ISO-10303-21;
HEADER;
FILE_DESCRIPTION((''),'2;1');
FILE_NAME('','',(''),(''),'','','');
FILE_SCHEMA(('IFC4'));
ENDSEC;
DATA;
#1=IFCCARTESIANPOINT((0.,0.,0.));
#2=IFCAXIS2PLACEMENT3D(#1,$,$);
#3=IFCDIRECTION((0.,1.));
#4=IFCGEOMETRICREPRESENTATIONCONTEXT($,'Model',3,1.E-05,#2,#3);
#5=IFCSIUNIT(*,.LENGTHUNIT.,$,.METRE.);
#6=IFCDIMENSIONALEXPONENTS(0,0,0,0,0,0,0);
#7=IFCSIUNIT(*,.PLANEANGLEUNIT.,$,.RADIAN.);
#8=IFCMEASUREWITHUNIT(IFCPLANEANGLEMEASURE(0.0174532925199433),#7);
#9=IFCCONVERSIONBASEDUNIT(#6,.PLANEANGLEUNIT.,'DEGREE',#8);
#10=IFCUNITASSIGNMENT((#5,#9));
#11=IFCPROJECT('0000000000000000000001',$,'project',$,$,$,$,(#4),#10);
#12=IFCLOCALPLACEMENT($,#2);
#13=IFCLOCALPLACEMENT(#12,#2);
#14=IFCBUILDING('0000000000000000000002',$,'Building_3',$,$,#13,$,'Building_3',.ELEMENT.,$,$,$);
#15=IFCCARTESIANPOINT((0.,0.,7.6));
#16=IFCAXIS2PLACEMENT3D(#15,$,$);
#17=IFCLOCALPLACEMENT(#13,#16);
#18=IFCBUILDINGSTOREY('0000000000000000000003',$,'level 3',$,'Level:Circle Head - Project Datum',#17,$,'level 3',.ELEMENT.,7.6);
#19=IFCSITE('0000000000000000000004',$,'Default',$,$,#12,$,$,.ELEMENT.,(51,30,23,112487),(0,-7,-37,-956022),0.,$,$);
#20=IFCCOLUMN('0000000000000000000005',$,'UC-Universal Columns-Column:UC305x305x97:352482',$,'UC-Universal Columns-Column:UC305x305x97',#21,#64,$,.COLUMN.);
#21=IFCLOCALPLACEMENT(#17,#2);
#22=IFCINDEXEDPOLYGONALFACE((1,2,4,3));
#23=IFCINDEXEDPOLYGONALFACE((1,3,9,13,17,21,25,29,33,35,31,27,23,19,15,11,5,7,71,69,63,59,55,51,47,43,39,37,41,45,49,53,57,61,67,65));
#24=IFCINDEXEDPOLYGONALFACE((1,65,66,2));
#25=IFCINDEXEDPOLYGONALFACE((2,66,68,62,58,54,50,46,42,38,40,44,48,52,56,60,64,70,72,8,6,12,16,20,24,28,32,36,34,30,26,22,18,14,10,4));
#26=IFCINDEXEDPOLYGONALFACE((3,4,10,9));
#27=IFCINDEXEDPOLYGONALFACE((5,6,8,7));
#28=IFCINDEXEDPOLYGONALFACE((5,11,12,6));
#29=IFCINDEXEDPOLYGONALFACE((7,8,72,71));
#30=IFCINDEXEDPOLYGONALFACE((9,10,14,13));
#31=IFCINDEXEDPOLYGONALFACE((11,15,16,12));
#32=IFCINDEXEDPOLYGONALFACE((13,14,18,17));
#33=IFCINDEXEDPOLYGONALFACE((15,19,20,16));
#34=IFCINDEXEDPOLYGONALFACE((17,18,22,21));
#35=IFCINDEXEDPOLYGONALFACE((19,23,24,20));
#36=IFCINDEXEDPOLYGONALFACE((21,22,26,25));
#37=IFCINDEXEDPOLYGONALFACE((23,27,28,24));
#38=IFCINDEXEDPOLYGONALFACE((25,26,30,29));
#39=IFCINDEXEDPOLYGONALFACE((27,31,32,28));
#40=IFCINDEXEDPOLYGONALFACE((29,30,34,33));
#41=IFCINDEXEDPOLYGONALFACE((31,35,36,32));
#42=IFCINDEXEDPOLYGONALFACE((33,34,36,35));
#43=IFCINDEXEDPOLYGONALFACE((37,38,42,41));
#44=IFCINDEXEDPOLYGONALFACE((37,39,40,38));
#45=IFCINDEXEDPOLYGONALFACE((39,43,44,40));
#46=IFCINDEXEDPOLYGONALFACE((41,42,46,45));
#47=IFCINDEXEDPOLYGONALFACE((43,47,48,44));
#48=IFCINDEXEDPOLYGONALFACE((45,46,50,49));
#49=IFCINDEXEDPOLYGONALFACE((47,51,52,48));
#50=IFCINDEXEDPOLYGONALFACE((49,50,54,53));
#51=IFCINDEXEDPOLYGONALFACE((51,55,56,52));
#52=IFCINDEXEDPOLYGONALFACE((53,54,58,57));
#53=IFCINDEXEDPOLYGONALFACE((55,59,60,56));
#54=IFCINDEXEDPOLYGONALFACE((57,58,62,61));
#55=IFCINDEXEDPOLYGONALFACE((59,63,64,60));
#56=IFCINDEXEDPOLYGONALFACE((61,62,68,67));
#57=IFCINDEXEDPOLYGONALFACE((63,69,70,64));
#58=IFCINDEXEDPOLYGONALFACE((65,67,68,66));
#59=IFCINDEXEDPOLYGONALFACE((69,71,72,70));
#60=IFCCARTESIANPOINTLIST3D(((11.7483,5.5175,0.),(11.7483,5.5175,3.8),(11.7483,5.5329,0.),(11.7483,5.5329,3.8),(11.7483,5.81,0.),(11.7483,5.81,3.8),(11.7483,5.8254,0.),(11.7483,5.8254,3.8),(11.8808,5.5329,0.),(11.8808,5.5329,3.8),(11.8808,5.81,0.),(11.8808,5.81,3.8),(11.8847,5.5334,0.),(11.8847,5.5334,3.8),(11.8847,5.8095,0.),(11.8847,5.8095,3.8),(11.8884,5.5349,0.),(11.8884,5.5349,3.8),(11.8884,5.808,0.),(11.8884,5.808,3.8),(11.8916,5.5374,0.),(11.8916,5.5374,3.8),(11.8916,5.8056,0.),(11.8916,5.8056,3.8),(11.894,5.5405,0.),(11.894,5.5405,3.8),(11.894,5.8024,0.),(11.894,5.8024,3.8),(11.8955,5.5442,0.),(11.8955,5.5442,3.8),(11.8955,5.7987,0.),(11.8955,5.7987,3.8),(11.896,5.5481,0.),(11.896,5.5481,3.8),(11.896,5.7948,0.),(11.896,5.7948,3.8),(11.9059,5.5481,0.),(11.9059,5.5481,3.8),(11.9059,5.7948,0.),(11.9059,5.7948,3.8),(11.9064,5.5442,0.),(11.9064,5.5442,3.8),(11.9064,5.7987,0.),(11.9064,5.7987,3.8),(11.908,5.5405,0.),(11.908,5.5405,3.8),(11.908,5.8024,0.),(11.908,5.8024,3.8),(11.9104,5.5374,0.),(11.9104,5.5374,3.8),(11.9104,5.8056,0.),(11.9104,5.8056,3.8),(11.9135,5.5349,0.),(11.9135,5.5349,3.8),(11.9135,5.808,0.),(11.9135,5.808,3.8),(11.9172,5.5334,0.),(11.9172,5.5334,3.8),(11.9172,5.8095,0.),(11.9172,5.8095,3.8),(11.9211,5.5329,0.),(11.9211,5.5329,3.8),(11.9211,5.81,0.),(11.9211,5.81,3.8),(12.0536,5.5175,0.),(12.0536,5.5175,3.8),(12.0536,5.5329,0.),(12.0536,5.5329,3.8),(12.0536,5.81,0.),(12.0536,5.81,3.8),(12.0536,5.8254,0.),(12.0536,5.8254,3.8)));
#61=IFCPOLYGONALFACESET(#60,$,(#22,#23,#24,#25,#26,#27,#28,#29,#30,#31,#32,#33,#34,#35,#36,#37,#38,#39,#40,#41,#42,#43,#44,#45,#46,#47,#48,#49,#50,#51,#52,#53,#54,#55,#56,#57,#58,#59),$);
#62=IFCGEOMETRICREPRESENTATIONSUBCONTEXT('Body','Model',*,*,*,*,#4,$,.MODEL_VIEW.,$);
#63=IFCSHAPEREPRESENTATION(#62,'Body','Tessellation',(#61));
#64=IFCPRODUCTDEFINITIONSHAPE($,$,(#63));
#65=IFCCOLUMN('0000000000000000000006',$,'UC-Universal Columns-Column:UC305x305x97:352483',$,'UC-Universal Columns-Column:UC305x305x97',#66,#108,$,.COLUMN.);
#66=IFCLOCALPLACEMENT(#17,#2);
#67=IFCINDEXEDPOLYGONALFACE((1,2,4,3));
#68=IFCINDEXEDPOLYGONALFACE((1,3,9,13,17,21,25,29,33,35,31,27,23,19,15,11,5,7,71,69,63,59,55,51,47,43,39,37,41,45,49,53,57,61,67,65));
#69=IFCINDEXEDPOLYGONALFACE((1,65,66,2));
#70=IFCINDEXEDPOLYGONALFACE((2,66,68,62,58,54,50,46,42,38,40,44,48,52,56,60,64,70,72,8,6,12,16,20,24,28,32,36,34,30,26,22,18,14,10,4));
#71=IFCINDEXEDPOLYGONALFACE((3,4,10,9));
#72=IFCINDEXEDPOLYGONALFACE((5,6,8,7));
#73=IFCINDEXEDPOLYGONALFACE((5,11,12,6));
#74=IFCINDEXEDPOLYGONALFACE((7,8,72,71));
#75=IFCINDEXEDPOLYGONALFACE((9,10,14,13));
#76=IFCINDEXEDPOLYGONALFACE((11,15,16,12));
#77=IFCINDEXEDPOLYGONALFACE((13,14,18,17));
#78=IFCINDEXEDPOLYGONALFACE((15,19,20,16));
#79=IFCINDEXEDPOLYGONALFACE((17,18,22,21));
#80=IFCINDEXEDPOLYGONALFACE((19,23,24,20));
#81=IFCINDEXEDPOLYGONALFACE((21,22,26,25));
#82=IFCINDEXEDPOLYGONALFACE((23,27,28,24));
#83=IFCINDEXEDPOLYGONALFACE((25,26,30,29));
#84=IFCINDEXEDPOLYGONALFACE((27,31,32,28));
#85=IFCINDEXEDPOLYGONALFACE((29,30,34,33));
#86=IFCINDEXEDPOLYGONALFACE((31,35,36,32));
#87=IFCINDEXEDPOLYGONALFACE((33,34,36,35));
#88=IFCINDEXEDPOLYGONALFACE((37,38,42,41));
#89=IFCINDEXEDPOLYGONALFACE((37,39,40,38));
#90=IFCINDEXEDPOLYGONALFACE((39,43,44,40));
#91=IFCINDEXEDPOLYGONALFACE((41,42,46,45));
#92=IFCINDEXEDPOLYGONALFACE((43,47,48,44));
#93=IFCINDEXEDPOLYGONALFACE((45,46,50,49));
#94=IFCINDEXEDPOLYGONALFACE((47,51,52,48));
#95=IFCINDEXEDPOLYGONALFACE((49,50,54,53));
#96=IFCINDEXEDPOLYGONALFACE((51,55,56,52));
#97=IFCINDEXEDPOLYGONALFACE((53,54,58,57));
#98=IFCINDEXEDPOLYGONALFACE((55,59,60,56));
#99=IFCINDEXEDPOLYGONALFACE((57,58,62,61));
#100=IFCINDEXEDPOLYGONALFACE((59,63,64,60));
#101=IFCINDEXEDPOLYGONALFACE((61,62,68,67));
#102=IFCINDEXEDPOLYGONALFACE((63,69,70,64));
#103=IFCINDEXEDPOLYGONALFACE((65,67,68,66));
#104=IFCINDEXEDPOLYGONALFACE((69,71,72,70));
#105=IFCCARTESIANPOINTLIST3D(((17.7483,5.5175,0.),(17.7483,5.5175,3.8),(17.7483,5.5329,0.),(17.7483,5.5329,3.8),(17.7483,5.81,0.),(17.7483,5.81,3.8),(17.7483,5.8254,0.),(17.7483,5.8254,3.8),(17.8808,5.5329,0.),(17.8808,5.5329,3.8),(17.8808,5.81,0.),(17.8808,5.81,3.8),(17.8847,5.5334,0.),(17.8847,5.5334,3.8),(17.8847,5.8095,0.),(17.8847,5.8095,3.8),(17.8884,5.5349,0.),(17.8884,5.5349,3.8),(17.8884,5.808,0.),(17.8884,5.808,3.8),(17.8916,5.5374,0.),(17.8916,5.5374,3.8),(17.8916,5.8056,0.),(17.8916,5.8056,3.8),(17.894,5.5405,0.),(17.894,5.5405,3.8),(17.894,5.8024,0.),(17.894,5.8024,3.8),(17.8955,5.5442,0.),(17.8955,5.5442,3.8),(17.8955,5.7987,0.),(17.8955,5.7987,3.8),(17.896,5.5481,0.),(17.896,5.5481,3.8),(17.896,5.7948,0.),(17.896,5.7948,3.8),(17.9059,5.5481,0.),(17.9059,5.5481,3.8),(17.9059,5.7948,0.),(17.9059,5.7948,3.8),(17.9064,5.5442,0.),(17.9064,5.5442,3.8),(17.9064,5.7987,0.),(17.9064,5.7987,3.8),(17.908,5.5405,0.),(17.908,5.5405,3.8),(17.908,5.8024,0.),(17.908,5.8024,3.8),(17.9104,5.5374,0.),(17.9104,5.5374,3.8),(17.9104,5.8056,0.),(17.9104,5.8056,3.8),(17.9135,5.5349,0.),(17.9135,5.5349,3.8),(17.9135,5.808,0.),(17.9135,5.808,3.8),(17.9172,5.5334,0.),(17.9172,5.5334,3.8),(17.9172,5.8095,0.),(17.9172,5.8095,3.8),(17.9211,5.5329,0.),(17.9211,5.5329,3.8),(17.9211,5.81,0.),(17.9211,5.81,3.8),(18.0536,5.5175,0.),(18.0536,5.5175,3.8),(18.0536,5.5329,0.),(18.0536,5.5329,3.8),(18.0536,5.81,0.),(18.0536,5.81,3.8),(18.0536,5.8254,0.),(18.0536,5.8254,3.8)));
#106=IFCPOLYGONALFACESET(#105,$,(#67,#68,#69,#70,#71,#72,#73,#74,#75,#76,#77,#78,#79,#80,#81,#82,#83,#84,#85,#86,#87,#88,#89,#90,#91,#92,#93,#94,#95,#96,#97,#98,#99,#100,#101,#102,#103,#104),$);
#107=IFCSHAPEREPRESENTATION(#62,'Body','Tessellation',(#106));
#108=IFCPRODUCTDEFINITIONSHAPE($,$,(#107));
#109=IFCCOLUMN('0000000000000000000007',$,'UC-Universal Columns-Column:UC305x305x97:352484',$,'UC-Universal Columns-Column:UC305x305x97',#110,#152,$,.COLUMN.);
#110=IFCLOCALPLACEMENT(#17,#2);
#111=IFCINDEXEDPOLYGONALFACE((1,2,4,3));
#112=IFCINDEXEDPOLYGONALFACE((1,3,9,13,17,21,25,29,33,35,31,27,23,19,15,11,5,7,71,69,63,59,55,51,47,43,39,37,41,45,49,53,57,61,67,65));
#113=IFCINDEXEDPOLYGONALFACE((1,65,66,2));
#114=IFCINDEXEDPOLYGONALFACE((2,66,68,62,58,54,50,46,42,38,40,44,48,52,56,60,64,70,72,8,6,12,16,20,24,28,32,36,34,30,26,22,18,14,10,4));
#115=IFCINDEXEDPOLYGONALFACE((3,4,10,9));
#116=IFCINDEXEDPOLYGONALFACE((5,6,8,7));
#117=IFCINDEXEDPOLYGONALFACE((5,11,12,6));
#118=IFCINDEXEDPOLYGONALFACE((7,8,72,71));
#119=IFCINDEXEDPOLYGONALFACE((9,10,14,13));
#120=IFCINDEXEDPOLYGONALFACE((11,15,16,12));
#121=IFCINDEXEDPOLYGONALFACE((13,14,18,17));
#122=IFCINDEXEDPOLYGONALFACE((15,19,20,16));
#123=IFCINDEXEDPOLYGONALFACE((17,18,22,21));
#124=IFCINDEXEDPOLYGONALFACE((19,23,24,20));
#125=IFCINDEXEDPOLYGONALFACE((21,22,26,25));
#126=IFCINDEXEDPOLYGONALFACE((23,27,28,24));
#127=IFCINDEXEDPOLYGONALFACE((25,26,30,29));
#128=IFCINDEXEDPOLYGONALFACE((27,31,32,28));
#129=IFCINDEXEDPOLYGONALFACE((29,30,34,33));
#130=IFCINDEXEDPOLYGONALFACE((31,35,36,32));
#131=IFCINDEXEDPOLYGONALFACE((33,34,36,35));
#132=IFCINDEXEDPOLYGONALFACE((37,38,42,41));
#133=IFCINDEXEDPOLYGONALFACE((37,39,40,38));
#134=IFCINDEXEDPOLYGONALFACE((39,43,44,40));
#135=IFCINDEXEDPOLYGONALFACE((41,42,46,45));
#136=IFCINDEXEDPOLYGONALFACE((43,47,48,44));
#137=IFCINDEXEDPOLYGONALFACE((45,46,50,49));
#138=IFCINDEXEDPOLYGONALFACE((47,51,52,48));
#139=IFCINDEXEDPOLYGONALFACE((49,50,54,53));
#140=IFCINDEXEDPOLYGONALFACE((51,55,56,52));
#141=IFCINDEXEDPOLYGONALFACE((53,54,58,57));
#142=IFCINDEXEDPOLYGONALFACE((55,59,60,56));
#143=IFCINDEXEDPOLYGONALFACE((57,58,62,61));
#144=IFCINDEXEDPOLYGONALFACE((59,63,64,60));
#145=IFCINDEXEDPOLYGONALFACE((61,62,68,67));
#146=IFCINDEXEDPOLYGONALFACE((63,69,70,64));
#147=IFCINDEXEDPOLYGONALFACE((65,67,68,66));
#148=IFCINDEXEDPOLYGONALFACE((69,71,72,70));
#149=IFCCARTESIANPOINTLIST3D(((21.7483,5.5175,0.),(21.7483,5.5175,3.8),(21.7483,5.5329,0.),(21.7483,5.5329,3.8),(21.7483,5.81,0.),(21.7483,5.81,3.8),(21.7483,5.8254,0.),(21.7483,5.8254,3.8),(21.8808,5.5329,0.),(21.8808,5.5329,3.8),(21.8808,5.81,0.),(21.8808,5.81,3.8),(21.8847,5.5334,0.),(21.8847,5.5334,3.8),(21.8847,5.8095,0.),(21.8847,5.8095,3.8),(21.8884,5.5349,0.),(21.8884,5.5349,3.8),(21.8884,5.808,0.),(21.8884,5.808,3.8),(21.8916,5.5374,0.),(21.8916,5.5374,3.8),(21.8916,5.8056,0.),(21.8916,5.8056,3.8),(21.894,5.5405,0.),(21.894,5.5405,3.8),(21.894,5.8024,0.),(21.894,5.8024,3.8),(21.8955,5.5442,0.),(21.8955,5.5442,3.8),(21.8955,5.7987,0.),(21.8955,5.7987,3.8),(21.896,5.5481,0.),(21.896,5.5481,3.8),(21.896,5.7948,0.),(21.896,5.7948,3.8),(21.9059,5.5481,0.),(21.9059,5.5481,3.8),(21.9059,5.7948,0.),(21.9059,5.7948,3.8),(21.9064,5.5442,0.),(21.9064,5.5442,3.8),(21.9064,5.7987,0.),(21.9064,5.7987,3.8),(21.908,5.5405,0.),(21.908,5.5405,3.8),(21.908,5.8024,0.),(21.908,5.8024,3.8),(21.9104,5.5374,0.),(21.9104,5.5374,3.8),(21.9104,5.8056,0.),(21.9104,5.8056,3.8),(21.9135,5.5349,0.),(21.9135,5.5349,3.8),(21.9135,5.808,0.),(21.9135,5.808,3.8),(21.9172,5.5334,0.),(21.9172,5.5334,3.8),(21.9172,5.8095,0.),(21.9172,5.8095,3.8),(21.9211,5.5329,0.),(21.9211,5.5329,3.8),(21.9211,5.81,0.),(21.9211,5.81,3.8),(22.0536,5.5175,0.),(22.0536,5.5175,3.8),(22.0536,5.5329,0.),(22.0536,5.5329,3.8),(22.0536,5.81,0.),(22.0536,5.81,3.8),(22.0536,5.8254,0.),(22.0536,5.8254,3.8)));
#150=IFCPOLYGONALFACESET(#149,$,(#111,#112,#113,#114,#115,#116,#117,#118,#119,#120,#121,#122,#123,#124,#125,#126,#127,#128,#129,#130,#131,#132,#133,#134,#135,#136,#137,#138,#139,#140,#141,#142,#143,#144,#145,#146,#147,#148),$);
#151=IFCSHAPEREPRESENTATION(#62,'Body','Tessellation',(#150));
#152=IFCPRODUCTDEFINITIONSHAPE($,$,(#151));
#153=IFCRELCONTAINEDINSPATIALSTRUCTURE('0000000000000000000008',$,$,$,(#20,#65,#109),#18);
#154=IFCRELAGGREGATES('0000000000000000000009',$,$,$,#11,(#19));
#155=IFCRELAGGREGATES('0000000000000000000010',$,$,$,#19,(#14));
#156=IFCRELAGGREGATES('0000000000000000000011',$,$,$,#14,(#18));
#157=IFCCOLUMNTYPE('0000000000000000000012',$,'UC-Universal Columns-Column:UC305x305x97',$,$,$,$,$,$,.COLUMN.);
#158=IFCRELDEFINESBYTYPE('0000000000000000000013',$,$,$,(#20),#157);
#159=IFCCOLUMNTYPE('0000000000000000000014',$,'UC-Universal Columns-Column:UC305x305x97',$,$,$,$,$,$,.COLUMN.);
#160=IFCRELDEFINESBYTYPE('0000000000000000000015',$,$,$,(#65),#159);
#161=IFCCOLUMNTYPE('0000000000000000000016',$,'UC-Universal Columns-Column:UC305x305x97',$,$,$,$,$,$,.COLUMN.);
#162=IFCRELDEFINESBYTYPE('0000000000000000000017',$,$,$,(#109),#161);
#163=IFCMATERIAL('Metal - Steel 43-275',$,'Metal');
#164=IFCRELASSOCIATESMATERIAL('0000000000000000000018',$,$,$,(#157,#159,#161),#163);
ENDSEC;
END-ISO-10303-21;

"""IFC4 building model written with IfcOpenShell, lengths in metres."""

from ifc_helpers import new_model, entity, si_unit, converted_unit, direction, frame, frame_2d, origin, place, context, subcontext, project, spatial, i_section, extrude, source, transform, mapped, material, material_profile, profile_set, type_object, type_shapes, element, save


model = new_model("IFC4")

# Units and contexts
model_context = context("Model", 3, precision=1e-05, world=origin(), true_north=direction((0.0, 1.0)))
body_context = subcontext(model_context, "Body", "Model", "MODEL_VIEW")
ifc_project = project(units=[si_unit("LENGTHUNIT", "METRE"), converted_unit("PLANEANGLEUNIT", "DEGREE", entity("IfcPlaneAngleMeasure", 0.0174532925199433), si_unit("PLANEANGLEUNIT", "RADIAN"), dimensions=[0, 0, 0, 0, 0, 0, 0])], contexts=[model_context])

# Site, building, storey
site_placement = place(None, origin())
site = spatial("IfcSite", under=ifc_project, at=site_placement, Name="Default", CompositionType="ELEMENT", RefLatitude=(51, 30, 23, 112487), RefLongitude=(0, -7, -37, -956022), RefElevation=0.0)
building_placement = place(site_placement, origin())
building = spatial("IfcBuilding", under=site, at=building_placement, Name="Building_3", LongName="Building_3", CompositionType="ELEMENT")
storey_placement = place(building_placement, frame((0.0, 0.0, 7.6)))
storey = spatial("IfcBuildingStorey", under=building, at=storey_placement, Name="level 3", ObjectType="Level:Circle Head - Project Datum", LongName="level 3", CompositionType="ELEMENT", Elevation=7.6)

# Columns
ifc_material_1 = material(Name="Metal - Steel 43-275", Category="Metal")
ifc_material_profile_1 = material_profile(ifc_material_1, i_section(OverallWidth=0.3053, OverallDepth=0.3079, WebThickness=0.0099, FlangeThickness=0.0154, FilletRadius=0.0152, at=frame_2d((0.0, 0.0), x_axis=(1.0, 0.0))), Name="UC305x305x97")
ifc_profile_set_1 = profile_set([ifc_material_profile_1], Name="UC305x305x97")
column_type_1 = type_object("IfcColumnType", Name="UC-Universal Columns-Column:UC305x305x97", PredefinedType="COLUMN", material=ifc_profile_set_1)
shared_shape_1 = source(origin(), body_context, "Body", "SweptSolid", [
    extrude(i_section(OverallWidth=0.3053, OverallDepth=0.3079, WebThickness=0.0099, FlangeThickness=0.0154, FilletRadius=0.0152, at=frame_2d((0.0, 0.0), x_axis=(1.0, 0.0))), frame((11.901, 5.6715, 7.6), z_axis=(0.0, 0.0, 1.0), x_axis=(-1.0, 0.0, 0.0)), (0.0, 0.0, 1.0), 3.8),
])
type_shapes(column_type_1, [shared_shape_1])
column_1_placement = place(storey_placement, frame((0.0, 0.0, -7.6)))
element("IfcColumn", 1, at=column_1_placement, inside=storey, type_object=column_type_1, Name="UC-Universal Columns-Column:UC305x305x97:352482", ObjectType="UC-Universal Columns-Column:UC305x305x97", PredefinedType="COLUMN", context=body_context, shape_type="MappedRepresentation", body=[
    mapped(shared_shape_1, transform((0.0, 0.0, 0.0), scale=1.0)),
])
column_type_2 = type_object("IfcColumnType", Name="UC-Universal Columns-Column:UC305x305x97", PredefinedType="COLUMN", material=ifc_profile_set_1)
shared_shape_2 = source(origin(), body_context, "Body", "SweptSolid", [
    extrude(i_section(OverallWidth=0.3053, OverallDepth=0.3079, WebThickness=0.0099, FlangeThickness=0.0154, FilletRadius=0.0152, at=frame_2d((0.0, 0.0), x_axis=(1.0, 0.0))), frame((17.901, 5.6715, 7.6), z_axis=(0.0, 0.0, 1.0), x_axis=(-1.0, 0.0, 0.0)), (0.0, 0.0, 1.0), 3.8),
])
type_shapes(column_type_2, [shared_shape_2])
column_2_placement = place(storey_placement, frame((0.0, 0.0, -7.6)))
element("IfcColumn", 2, at=column_2_placement, inside=storey, type_object=column_type_2, Name="UC-Universal Columns-Column:UC305x305x97:352483", ObjectType="UC-Universal Columns-Column:UC305x305x97", PredefinedType="COLUMN", context=body_context, shape_type="MappedRepresentation", body=[
    mapped(shared_shape_2, transform((0.0, 0.0, 0.0), scale=1.0)),
])
column_type_3 = type_object("IfcColumnType", Name="UC-Universal Columns-Column:UC305x305x97", PredefinedType="COLUMN", material=ifc_profile_set_1)
shared_shape_3 = source(origin(), body_context, "Body", "SweptSolid", [
    extrude(i_section(OverallWidth=0.3053, OverallDepth=0.3079, WebThickness=0.0099, FlangeThickness=0.0154, FilletRadius=0.0152, at=frame_2d((0.0, 0.0), x_axis=(1.0, 0.0))), frame((21.901, 5.6715, 7.6), z_axis=(0.0, 0.0, 1.0), x_axis=(-1.0, 0.0, 0.0)), (0.0, 0.0, 1.0), 3.8),
])
type_shapes(column_type_3, [shared_shape_3])
column_3_placement = place(storey_placement, frame((0.0, 0.0, -7.6)))
element("IfcColumn", 3, at=column_3_placement, inside=storey, type_object=column_type_3, Name="UC-Universal Columns-Column:UC305x305x97:352484", ObjectType="UC-Universal Columns-Column:UC305x305x97", PredefinedType="COLUMN", context=body_context, shape_type="MappedRepresentation", body=[
    mapped(shared_shape_3, transform((0.0, 0.0, 0.0), scale=1.0)),
])

save(model, "model.ifc")
